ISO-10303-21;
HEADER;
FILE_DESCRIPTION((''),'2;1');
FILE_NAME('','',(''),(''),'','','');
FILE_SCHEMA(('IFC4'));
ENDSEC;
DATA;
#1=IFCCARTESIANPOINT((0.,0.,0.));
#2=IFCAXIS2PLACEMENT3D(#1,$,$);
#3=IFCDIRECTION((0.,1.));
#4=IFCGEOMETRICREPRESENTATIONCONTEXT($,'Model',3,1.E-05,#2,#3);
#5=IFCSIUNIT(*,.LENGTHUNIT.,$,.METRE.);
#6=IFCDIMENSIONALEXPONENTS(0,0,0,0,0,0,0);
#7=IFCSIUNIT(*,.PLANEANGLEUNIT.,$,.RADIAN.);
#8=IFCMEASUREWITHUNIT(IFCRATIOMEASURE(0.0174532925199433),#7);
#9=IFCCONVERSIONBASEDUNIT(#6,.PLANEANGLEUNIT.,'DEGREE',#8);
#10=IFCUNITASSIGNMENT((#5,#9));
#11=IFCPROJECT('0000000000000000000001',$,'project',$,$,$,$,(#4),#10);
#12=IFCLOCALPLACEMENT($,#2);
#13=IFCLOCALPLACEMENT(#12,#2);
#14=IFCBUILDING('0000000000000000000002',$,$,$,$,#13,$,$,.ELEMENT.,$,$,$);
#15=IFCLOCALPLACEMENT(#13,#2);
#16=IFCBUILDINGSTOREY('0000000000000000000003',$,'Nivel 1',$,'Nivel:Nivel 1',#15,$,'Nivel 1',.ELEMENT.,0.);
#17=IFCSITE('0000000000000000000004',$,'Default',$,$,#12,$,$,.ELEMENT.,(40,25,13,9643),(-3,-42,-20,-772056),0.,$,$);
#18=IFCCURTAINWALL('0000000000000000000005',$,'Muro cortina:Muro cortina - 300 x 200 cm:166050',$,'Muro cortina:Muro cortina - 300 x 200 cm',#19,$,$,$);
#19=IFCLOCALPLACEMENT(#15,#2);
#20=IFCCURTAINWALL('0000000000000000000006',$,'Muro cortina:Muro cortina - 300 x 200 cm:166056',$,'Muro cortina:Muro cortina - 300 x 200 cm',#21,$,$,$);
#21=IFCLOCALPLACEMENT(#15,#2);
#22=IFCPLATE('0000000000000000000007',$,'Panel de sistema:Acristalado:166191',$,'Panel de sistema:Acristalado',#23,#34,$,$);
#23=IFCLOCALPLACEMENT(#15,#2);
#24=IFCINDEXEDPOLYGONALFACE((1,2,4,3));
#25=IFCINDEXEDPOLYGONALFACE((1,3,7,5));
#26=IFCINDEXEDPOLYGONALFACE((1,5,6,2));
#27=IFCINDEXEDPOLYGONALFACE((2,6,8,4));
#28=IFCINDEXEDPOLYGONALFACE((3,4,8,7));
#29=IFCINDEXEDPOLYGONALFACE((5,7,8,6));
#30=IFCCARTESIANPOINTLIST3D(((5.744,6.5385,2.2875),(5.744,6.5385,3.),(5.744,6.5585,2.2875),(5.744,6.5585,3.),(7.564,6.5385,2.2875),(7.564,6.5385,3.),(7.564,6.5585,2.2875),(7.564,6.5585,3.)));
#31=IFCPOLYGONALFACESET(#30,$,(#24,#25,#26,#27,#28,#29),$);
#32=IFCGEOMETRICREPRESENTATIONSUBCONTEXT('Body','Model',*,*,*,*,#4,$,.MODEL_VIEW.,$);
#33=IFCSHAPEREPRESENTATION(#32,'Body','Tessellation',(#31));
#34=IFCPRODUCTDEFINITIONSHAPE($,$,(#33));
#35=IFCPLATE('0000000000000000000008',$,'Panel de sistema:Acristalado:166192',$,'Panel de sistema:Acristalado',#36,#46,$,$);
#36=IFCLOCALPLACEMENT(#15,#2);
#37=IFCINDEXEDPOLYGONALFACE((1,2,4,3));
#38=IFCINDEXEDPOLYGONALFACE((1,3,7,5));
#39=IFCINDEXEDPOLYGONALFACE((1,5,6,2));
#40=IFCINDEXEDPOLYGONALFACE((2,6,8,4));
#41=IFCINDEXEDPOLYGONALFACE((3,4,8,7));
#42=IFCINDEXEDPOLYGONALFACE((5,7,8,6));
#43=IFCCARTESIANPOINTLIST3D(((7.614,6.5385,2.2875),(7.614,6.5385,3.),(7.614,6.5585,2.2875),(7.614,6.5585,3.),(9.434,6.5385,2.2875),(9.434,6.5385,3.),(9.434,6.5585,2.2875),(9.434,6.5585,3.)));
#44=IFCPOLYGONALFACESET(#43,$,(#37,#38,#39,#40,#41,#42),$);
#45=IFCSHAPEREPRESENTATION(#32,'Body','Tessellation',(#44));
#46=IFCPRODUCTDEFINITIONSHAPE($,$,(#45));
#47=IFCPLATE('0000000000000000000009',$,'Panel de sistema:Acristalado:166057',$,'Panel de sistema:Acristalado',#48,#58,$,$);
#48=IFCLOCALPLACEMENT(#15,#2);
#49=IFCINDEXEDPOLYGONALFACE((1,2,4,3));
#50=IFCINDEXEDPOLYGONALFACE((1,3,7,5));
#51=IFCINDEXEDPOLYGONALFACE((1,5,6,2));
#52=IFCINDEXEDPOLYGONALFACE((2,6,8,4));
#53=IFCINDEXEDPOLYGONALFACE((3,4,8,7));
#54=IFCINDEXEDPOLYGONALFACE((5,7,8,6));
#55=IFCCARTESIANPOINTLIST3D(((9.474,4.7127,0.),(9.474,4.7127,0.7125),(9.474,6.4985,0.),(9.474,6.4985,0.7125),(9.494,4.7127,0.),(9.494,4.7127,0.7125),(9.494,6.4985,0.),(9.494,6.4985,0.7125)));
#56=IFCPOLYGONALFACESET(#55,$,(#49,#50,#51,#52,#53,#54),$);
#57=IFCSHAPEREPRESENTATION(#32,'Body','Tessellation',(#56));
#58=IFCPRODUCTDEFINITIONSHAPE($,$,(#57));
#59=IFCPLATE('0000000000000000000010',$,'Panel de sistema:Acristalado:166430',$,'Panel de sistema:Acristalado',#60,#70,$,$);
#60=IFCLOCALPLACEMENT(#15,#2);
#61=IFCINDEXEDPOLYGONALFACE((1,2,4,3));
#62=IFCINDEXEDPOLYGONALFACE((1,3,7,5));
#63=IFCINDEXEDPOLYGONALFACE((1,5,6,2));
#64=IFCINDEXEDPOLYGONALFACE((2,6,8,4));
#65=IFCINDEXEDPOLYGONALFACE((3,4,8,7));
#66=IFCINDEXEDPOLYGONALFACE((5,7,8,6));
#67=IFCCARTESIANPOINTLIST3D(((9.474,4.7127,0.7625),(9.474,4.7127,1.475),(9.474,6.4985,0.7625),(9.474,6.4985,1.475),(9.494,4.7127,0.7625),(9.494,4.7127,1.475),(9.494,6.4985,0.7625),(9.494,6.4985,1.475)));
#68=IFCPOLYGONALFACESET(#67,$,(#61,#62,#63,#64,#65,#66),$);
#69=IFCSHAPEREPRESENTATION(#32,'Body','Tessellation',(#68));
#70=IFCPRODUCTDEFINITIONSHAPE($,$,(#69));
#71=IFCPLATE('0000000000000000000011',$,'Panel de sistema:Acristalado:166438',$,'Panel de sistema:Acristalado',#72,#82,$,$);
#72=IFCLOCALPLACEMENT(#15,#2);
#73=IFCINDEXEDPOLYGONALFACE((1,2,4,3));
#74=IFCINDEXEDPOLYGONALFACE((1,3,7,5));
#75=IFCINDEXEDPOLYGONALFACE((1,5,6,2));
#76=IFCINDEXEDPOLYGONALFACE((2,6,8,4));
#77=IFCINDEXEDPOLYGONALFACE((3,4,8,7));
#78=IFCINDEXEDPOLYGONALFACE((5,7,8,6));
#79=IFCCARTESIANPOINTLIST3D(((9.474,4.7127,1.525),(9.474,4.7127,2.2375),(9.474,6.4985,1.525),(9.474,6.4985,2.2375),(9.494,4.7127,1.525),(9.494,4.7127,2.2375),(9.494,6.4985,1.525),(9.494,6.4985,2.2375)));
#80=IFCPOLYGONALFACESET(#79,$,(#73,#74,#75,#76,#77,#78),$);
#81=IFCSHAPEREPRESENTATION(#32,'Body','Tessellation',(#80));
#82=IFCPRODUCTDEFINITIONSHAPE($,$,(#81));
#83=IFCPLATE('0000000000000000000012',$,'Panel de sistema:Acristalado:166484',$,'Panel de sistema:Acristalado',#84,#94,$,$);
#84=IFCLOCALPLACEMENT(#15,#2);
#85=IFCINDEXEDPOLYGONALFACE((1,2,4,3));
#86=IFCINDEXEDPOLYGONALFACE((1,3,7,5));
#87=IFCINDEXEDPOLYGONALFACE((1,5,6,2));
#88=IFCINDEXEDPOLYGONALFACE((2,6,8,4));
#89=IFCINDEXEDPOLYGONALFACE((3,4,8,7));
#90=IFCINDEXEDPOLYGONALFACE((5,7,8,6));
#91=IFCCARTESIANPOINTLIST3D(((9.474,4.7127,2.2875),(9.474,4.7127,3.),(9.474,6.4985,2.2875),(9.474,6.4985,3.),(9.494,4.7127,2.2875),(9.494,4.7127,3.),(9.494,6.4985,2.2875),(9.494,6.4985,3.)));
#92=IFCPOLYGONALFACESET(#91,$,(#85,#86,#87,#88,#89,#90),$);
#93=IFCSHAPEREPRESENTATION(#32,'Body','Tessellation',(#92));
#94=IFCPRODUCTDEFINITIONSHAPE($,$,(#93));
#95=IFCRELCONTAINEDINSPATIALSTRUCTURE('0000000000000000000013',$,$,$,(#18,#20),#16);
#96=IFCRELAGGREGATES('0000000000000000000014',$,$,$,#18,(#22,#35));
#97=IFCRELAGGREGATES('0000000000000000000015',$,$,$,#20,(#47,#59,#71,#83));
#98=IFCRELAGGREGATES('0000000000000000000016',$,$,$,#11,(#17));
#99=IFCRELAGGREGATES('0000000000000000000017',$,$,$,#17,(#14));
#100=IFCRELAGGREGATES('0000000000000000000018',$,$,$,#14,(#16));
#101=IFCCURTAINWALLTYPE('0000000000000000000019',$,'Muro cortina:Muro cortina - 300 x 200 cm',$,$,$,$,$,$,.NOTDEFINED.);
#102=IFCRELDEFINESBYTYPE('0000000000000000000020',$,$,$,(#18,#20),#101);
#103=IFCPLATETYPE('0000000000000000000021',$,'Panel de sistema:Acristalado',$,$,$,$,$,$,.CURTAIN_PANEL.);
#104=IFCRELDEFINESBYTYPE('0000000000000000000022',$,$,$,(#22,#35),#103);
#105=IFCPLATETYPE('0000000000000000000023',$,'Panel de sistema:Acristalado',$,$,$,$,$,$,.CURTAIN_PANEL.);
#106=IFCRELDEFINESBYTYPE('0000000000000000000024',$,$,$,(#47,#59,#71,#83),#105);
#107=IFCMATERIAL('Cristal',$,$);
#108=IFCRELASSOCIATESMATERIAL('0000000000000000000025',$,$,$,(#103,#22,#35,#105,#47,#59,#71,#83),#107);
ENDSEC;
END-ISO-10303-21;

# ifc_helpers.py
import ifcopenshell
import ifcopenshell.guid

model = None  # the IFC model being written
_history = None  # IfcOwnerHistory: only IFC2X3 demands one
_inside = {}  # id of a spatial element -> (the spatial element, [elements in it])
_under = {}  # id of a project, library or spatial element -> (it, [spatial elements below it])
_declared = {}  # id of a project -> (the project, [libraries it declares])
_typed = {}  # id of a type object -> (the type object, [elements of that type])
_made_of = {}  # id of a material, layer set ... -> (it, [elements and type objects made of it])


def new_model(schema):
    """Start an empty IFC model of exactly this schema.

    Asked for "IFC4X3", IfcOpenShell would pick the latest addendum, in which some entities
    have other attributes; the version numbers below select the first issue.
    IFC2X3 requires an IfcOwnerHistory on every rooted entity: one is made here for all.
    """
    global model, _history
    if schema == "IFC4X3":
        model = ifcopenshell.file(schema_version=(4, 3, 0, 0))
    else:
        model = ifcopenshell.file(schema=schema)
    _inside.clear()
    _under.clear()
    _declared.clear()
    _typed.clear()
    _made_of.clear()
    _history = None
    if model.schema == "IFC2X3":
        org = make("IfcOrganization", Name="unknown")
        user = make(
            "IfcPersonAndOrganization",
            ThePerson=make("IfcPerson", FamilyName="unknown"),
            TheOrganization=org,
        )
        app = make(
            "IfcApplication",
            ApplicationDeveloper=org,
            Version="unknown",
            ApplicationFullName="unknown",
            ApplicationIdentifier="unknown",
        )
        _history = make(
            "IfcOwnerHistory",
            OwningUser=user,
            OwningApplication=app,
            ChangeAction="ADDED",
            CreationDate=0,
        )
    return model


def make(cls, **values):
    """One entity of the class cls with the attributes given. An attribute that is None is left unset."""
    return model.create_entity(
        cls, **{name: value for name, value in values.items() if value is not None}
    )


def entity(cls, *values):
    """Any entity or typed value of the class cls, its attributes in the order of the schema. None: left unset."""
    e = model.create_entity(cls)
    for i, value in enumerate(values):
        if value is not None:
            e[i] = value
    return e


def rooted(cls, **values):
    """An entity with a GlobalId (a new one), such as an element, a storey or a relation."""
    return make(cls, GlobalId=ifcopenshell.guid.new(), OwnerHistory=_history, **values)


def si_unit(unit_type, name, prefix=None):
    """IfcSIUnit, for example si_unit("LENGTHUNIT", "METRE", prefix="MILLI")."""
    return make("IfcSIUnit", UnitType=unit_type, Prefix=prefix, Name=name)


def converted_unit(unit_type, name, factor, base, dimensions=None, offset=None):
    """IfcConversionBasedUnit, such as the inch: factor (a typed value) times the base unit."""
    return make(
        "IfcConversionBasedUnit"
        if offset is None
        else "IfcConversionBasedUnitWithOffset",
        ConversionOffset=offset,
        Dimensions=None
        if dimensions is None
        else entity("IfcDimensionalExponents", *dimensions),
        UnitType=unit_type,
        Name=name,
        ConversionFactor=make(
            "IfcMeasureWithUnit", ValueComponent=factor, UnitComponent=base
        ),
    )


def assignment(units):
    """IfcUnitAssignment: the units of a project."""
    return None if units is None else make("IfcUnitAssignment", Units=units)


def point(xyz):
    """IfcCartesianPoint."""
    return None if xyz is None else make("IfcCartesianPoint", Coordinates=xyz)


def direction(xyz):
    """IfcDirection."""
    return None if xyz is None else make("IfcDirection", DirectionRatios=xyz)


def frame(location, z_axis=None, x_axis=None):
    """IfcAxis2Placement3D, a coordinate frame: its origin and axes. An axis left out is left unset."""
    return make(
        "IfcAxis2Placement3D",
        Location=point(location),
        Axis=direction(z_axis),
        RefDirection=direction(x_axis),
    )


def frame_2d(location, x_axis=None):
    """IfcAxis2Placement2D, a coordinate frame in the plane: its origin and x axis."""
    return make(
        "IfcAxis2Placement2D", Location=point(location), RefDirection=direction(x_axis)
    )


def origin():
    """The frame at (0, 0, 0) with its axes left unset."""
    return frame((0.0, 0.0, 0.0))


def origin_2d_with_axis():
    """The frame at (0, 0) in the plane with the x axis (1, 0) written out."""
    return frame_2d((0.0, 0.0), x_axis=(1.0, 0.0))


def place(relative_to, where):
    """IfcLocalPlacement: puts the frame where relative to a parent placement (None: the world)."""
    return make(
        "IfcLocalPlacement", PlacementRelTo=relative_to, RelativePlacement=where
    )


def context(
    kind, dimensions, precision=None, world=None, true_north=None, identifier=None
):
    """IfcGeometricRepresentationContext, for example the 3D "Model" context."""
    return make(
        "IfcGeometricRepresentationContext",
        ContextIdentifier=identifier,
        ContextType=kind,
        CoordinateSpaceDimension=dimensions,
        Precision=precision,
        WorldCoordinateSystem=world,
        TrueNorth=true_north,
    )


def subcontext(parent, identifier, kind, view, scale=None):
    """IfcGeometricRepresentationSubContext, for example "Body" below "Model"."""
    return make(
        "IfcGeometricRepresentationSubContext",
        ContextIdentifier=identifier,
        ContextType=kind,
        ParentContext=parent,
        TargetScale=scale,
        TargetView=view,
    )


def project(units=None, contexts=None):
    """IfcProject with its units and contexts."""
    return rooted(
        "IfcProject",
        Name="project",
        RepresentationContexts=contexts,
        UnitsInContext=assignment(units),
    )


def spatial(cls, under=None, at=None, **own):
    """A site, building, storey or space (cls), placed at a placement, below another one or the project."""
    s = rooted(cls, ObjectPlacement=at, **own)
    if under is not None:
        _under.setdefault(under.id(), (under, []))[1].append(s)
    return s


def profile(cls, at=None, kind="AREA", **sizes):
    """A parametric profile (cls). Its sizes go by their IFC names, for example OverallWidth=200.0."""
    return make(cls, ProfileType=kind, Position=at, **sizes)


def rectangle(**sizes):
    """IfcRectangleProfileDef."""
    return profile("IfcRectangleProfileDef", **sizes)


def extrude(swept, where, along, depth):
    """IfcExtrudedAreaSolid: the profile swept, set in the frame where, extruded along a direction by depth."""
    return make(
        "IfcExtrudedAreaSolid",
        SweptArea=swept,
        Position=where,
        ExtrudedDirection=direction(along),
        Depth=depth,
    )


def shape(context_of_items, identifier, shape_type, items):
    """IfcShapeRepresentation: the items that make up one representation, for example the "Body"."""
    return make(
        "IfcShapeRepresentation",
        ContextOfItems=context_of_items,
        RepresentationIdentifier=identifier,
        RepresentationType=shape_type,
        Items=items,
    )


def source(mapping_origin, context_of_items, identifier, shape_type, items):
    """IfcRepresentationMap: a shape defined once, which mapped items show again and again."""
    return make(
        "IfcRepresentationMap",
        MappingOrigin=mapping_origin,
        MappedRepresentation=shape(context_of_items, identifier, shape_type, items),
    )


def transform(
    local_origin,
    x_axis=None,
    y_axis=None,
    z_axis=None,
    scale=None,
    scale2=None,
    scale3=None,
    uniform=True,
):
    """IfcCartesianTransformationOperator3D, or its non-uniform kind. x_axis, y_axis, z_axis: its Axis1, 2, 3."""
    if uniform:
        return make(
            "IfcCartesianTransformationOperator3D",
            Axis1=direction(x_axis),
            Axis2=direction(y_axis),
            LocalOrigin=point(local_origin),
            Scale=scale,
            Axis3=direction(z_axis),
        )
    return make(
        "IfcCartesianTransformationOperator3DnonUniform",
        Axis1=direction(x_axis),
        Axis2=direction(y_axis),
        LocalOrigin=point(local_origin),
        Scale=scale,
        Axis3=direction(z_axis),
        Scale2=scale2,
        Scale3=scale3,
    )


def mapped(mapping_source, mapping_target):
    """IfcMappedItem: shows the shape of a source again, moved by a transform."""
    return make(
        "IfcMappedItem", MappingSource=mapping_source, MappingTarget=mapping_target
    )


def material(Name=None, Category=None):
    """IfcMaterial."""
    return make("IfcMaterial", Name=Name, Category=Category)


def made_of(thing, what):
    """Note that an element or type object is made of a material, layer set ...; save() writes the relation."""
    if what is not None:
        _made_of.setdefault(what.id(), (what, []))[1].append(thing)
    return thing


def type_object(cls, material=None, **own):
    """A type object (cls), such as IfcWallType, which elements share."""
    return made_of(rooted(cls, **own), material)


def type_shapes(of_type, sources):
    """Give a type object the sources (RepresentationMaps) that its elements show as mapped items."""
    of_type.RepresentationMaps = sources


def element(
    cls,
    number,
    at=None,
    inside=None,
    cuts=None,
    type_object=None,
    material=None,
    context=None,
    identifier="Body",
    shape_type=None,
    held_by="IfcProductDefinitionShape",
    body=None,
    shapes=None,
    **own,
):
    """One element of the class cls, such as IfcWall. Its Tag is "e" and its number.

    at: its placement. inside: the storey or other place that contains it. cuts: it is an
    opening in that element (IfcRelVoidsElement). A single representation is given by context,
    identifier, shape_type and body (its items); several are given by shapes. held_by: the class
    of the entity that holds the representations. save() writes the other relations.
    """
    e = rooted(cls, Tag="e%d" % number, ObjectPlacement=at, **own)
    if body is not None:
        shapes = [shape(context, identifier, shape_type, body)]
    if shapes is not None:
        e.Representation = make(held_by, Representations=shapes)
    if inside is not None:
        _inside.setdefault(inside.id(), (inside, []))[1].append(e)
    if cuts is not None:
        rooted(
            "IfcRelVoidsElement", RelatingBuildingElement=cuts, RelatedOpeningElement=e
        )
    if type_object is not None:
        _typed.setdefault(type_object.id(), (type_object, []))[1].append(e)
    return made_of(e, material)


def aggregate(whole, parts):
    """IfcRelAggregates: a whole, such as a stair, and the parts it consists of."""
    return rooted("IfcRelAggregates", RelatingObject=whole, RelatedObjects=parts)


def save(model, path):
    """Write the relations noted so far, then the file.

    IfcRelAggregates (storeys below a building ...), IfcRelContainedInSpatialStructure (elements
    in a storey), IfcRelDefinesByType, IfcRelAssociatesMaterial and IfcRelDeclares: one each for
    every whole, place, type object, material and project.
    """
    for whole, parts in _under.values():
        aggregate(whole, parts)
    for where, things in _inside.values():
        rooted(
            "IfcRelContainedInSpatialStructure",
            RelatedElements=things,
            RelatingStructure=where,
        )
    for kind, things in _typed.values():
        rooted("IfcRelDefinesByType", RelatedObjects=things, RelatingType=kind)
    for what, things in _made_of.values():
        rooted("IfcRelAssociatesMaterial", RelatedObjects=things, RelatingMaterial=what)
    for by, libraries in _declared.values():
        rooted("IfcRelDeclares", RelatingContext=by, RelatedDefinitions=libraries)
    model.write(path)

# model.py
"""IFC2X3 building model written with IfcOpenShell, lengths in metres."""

from ifc_helpers import new_model, entity, si_unit, converted_unit, direction, frame, origin, origin_2d_with_axis, place, context, subcontext, project, spatial, rectangle, extrude, source, transform, mapped, material, type_object, type_shapes, element, aggregate, save


model = new_model("IFC2X3")

# Units and contexts
model_context = context("Model", 3, precision=1e-05, world=origin(), true_north=direction((0.0, 1.0)))
body_context = subcontext(model_context, "Body", "Model", "MODEL_VIEW")
ifc_project = project(units=[si_unit("LENGTHUNIT", "METRE"), converted_unit("PLANEANGLEUNIT", "DEGREE", entity("IfcRatioMeasure", 0.0174532925199433), si_unit("PLANEANGLEUNIT", "RADIAN"), dimensions=[0, 0, 0, 0, 0, 0, 0])], contexts=[model_context])

# Site, building, storey
site_placement = place(None, origin())
site = spatial("IfcSite", under=ifc_project, at=site_placement, Name="Default", CompositionType="ELEMENT", RefLatitude=(40, 25, 13, 9643), RefLongitude=(-3, -42, -20, -772056), RefElevation=0.0)
building_placement = place(site_placement, origin())
building = spatial("IfcBuilding", under=site, at=building_placement, CompositionType="ELEMENT")
storey_placement = place(building_placement, origin())
storey = spatial("IfcBuildingStorey", under=building, at=storey_placement, Name="Nivel 1", ObjectType="Nivel:Nivel 1", LongName="Nivel 1", CompositionType="ELEMENT", Elevation=0.0)

# Curtain walls
curtain_wall_type = type_object("IfcCurtainWallType", Name="Muro cortina:Muro cortina - 300 x 200 cm", PredefinedType="NOTDEFINED")
curtain_wall_1_placement = place(storey_placement, origin())
curtain_wall_1 = element("IfcCurtainWall", 1, at=curtain_wall_1_placement, inside=storey, type_object=curtain_wall_type, Name="Muro cortina:Muro cortina - 300 x 200 cm:166050", ObjectType="Muro cortina:Muro cortina - 300 x 200 cm")
curtain_wall_2_placement = place(storey_placement, origin())
curtain_wall_2 = element("IfcCurtainWall", 2, at=curtain_wall_2_placement, inside=storey, type_object=curtain_wall_type, Name="Muro cortina:Muro cortina - 300 x 200 cm:166056", ObjectType="Muro cortina:Muro cortina - 300 x 200 cm")

# Plates
ifc_material_1 = material(Name="Cristal")
plate_type_1 = type_object("IfcPlateType", Name="Panel de sistema:Acristalado", PredefinedType="CURTAIN_PANEL", material=ifc_material_1)
shared_shape_1 = source(origin(), body_context, "Body", "SweptSolid", [
    extrude(rectangle(XDim=0.02, YDim=1.82, at=origin_2d_with_axis()), frame((0.0, 0.0, 0.0), z_axis=(0.0, 0.0, 1.0), x_axis=(0.0, 1.0, 0.0)), (0.0, 0.0, 1.0), 0.7125),
])
type_shapes(plate_type_1, [shared_shape_1])
plate_1_placement = place(curtain_wall_1_placement, frame((6.654, 6.5485, 2.2875)))
plate_1 = element("IfcPlate", 3, at=plate_1_placement, type_object=plate_type_1, material=ifc_material_1, Name="Panel de sistema:Acristalado:166191", ObjectType="Panel de sistema:Acristalado", context=body_context, shape_type="MappedRepresentation", body=[
    mapped(shared_shape_1, transform((0.0, 0.0, 0.0), scale=1.0)),
])
plate_2_placement = place(curtain_wall_1_placement, frame((8.524, 6.5485, 2.2875)))
plate_2 = element("IfcPlate", 4, at=plate_2_placement, type_object=plate_type_1, material=ifc_material_1, Name="Panel de sistema:Acristalado:166192", ObjectType="Panel de sistema:Acristalado", context=body_context, shape_type="MappedRepresentation", body=[
    mapped(shared_shape_1, transform((0.0, 0.0, 0.0), scale=1.0)),
])
aggregate(curtain_wall_1, [plate_1, plate_2])
plate_type_2 = type_object("IfcPlateType", Name="Panel de sistema:Acristalado", PredefinedType="CURTAIN_PANEL", material=ifc_material_1)
shared_shape_2 = source(origin(), body_context, "Body", "SweptSolid", [
    extrude(rectangle(XDim=0.02, YDim=1.7857, at=origin_2d_with_axis()), frame((0.0, 0.0, 0.0), z_axis=(0.0, 0.0, 1.0), x_axis=(0.0, 1.0, 0.0)), (0.0, 0.0, 1.0), 0.7125),
])
type_shapes(plate_type_2, [shared_shape_2])
plate_3_placement = place(curtain_wall_2_placement, frame((9.484, 5.6056, 0.0), z_axis=(0.0, 0.0, 1.0), x_axis=(0.0, -1.0, 0.0)))
plate_3 = element("IfcPlate", 5, at=plate_3_placement, type_object=plate_type_2, material=ifc_material_1, Name="Panel de sistema:Acristalado:166057", ObjectType="Panel de sistema:Acristalado", context=body_context, shape_type="MappedRepresentation", body=[
    mapped(shared_shape_2, transform((0.0, 0.0, 0.0), scale=1.0)),
])
plate_4_placement = place(curtain_wall_2_placement, frame((9.484, 5.6056, 0.7625), z_axis=(0.0, 0.0, 1.0), x_axis=(0.0, -1.0, 0.0)))
plate_4 = element("IfcPlate", 6, at=plate_4_placement, type_object=plate_type_2, material=ifc_material_1, Name="Panel de sistema:Acristalado:166430", ObjectType="Panel de sistema:Acristalado", context=body_context, shape_type="MappedRepresentation", body=[
    mapped(shared_shape_2, transform((0.0, 0.0, 0.0), scale=1.0)),
])
plate_5_placement = place(curtain_wall_2_placement, frame((9.484, 5.6056, 1.525), z_axis=(0.0, 0.0, 1.0), x_axis=(0.0, -1.0, 0.0)))
plate_5 = element("IfcPlate", 7, at=plate_5_placement, type_object=plate_type_2, material=ifc_material_1, Name="Panel de sistema:Acristalado:166438", ObjectType="Panel de sistema:Acristalado", context=body_context, shape_type="MappedRepresentation", body=[
    mapped(shared_shape_2, transform((0.0, 0.0, 0.0), scale=1.0)),
])
plate_6_placement = place(curtain_wall_2_placement, frame((9.484, 5.6056, 2.2875), z_axis=(0.0, 0.0, 1.0), x_axis=(0.0, -1.0, 0.0)))
plate_6 = element("IfcPlate", 8, at=plate_6_placement, type_object=plate_type_2, material=ifc_material_1, Name="Panel de sistema:Acristalado:166484", ObjectType="Panel de sistema:Acristalado", context=body_context, shape_type="MappedRepresentation", body=[
    mapped(shared_shape_2, transform((0.0, 0.0, 0.0), scale=1.0)),
])
aggregate(curtain_wall_2, [plate_3, plate_4, plate_5, plate_6])

save(model, "model.ifc")
